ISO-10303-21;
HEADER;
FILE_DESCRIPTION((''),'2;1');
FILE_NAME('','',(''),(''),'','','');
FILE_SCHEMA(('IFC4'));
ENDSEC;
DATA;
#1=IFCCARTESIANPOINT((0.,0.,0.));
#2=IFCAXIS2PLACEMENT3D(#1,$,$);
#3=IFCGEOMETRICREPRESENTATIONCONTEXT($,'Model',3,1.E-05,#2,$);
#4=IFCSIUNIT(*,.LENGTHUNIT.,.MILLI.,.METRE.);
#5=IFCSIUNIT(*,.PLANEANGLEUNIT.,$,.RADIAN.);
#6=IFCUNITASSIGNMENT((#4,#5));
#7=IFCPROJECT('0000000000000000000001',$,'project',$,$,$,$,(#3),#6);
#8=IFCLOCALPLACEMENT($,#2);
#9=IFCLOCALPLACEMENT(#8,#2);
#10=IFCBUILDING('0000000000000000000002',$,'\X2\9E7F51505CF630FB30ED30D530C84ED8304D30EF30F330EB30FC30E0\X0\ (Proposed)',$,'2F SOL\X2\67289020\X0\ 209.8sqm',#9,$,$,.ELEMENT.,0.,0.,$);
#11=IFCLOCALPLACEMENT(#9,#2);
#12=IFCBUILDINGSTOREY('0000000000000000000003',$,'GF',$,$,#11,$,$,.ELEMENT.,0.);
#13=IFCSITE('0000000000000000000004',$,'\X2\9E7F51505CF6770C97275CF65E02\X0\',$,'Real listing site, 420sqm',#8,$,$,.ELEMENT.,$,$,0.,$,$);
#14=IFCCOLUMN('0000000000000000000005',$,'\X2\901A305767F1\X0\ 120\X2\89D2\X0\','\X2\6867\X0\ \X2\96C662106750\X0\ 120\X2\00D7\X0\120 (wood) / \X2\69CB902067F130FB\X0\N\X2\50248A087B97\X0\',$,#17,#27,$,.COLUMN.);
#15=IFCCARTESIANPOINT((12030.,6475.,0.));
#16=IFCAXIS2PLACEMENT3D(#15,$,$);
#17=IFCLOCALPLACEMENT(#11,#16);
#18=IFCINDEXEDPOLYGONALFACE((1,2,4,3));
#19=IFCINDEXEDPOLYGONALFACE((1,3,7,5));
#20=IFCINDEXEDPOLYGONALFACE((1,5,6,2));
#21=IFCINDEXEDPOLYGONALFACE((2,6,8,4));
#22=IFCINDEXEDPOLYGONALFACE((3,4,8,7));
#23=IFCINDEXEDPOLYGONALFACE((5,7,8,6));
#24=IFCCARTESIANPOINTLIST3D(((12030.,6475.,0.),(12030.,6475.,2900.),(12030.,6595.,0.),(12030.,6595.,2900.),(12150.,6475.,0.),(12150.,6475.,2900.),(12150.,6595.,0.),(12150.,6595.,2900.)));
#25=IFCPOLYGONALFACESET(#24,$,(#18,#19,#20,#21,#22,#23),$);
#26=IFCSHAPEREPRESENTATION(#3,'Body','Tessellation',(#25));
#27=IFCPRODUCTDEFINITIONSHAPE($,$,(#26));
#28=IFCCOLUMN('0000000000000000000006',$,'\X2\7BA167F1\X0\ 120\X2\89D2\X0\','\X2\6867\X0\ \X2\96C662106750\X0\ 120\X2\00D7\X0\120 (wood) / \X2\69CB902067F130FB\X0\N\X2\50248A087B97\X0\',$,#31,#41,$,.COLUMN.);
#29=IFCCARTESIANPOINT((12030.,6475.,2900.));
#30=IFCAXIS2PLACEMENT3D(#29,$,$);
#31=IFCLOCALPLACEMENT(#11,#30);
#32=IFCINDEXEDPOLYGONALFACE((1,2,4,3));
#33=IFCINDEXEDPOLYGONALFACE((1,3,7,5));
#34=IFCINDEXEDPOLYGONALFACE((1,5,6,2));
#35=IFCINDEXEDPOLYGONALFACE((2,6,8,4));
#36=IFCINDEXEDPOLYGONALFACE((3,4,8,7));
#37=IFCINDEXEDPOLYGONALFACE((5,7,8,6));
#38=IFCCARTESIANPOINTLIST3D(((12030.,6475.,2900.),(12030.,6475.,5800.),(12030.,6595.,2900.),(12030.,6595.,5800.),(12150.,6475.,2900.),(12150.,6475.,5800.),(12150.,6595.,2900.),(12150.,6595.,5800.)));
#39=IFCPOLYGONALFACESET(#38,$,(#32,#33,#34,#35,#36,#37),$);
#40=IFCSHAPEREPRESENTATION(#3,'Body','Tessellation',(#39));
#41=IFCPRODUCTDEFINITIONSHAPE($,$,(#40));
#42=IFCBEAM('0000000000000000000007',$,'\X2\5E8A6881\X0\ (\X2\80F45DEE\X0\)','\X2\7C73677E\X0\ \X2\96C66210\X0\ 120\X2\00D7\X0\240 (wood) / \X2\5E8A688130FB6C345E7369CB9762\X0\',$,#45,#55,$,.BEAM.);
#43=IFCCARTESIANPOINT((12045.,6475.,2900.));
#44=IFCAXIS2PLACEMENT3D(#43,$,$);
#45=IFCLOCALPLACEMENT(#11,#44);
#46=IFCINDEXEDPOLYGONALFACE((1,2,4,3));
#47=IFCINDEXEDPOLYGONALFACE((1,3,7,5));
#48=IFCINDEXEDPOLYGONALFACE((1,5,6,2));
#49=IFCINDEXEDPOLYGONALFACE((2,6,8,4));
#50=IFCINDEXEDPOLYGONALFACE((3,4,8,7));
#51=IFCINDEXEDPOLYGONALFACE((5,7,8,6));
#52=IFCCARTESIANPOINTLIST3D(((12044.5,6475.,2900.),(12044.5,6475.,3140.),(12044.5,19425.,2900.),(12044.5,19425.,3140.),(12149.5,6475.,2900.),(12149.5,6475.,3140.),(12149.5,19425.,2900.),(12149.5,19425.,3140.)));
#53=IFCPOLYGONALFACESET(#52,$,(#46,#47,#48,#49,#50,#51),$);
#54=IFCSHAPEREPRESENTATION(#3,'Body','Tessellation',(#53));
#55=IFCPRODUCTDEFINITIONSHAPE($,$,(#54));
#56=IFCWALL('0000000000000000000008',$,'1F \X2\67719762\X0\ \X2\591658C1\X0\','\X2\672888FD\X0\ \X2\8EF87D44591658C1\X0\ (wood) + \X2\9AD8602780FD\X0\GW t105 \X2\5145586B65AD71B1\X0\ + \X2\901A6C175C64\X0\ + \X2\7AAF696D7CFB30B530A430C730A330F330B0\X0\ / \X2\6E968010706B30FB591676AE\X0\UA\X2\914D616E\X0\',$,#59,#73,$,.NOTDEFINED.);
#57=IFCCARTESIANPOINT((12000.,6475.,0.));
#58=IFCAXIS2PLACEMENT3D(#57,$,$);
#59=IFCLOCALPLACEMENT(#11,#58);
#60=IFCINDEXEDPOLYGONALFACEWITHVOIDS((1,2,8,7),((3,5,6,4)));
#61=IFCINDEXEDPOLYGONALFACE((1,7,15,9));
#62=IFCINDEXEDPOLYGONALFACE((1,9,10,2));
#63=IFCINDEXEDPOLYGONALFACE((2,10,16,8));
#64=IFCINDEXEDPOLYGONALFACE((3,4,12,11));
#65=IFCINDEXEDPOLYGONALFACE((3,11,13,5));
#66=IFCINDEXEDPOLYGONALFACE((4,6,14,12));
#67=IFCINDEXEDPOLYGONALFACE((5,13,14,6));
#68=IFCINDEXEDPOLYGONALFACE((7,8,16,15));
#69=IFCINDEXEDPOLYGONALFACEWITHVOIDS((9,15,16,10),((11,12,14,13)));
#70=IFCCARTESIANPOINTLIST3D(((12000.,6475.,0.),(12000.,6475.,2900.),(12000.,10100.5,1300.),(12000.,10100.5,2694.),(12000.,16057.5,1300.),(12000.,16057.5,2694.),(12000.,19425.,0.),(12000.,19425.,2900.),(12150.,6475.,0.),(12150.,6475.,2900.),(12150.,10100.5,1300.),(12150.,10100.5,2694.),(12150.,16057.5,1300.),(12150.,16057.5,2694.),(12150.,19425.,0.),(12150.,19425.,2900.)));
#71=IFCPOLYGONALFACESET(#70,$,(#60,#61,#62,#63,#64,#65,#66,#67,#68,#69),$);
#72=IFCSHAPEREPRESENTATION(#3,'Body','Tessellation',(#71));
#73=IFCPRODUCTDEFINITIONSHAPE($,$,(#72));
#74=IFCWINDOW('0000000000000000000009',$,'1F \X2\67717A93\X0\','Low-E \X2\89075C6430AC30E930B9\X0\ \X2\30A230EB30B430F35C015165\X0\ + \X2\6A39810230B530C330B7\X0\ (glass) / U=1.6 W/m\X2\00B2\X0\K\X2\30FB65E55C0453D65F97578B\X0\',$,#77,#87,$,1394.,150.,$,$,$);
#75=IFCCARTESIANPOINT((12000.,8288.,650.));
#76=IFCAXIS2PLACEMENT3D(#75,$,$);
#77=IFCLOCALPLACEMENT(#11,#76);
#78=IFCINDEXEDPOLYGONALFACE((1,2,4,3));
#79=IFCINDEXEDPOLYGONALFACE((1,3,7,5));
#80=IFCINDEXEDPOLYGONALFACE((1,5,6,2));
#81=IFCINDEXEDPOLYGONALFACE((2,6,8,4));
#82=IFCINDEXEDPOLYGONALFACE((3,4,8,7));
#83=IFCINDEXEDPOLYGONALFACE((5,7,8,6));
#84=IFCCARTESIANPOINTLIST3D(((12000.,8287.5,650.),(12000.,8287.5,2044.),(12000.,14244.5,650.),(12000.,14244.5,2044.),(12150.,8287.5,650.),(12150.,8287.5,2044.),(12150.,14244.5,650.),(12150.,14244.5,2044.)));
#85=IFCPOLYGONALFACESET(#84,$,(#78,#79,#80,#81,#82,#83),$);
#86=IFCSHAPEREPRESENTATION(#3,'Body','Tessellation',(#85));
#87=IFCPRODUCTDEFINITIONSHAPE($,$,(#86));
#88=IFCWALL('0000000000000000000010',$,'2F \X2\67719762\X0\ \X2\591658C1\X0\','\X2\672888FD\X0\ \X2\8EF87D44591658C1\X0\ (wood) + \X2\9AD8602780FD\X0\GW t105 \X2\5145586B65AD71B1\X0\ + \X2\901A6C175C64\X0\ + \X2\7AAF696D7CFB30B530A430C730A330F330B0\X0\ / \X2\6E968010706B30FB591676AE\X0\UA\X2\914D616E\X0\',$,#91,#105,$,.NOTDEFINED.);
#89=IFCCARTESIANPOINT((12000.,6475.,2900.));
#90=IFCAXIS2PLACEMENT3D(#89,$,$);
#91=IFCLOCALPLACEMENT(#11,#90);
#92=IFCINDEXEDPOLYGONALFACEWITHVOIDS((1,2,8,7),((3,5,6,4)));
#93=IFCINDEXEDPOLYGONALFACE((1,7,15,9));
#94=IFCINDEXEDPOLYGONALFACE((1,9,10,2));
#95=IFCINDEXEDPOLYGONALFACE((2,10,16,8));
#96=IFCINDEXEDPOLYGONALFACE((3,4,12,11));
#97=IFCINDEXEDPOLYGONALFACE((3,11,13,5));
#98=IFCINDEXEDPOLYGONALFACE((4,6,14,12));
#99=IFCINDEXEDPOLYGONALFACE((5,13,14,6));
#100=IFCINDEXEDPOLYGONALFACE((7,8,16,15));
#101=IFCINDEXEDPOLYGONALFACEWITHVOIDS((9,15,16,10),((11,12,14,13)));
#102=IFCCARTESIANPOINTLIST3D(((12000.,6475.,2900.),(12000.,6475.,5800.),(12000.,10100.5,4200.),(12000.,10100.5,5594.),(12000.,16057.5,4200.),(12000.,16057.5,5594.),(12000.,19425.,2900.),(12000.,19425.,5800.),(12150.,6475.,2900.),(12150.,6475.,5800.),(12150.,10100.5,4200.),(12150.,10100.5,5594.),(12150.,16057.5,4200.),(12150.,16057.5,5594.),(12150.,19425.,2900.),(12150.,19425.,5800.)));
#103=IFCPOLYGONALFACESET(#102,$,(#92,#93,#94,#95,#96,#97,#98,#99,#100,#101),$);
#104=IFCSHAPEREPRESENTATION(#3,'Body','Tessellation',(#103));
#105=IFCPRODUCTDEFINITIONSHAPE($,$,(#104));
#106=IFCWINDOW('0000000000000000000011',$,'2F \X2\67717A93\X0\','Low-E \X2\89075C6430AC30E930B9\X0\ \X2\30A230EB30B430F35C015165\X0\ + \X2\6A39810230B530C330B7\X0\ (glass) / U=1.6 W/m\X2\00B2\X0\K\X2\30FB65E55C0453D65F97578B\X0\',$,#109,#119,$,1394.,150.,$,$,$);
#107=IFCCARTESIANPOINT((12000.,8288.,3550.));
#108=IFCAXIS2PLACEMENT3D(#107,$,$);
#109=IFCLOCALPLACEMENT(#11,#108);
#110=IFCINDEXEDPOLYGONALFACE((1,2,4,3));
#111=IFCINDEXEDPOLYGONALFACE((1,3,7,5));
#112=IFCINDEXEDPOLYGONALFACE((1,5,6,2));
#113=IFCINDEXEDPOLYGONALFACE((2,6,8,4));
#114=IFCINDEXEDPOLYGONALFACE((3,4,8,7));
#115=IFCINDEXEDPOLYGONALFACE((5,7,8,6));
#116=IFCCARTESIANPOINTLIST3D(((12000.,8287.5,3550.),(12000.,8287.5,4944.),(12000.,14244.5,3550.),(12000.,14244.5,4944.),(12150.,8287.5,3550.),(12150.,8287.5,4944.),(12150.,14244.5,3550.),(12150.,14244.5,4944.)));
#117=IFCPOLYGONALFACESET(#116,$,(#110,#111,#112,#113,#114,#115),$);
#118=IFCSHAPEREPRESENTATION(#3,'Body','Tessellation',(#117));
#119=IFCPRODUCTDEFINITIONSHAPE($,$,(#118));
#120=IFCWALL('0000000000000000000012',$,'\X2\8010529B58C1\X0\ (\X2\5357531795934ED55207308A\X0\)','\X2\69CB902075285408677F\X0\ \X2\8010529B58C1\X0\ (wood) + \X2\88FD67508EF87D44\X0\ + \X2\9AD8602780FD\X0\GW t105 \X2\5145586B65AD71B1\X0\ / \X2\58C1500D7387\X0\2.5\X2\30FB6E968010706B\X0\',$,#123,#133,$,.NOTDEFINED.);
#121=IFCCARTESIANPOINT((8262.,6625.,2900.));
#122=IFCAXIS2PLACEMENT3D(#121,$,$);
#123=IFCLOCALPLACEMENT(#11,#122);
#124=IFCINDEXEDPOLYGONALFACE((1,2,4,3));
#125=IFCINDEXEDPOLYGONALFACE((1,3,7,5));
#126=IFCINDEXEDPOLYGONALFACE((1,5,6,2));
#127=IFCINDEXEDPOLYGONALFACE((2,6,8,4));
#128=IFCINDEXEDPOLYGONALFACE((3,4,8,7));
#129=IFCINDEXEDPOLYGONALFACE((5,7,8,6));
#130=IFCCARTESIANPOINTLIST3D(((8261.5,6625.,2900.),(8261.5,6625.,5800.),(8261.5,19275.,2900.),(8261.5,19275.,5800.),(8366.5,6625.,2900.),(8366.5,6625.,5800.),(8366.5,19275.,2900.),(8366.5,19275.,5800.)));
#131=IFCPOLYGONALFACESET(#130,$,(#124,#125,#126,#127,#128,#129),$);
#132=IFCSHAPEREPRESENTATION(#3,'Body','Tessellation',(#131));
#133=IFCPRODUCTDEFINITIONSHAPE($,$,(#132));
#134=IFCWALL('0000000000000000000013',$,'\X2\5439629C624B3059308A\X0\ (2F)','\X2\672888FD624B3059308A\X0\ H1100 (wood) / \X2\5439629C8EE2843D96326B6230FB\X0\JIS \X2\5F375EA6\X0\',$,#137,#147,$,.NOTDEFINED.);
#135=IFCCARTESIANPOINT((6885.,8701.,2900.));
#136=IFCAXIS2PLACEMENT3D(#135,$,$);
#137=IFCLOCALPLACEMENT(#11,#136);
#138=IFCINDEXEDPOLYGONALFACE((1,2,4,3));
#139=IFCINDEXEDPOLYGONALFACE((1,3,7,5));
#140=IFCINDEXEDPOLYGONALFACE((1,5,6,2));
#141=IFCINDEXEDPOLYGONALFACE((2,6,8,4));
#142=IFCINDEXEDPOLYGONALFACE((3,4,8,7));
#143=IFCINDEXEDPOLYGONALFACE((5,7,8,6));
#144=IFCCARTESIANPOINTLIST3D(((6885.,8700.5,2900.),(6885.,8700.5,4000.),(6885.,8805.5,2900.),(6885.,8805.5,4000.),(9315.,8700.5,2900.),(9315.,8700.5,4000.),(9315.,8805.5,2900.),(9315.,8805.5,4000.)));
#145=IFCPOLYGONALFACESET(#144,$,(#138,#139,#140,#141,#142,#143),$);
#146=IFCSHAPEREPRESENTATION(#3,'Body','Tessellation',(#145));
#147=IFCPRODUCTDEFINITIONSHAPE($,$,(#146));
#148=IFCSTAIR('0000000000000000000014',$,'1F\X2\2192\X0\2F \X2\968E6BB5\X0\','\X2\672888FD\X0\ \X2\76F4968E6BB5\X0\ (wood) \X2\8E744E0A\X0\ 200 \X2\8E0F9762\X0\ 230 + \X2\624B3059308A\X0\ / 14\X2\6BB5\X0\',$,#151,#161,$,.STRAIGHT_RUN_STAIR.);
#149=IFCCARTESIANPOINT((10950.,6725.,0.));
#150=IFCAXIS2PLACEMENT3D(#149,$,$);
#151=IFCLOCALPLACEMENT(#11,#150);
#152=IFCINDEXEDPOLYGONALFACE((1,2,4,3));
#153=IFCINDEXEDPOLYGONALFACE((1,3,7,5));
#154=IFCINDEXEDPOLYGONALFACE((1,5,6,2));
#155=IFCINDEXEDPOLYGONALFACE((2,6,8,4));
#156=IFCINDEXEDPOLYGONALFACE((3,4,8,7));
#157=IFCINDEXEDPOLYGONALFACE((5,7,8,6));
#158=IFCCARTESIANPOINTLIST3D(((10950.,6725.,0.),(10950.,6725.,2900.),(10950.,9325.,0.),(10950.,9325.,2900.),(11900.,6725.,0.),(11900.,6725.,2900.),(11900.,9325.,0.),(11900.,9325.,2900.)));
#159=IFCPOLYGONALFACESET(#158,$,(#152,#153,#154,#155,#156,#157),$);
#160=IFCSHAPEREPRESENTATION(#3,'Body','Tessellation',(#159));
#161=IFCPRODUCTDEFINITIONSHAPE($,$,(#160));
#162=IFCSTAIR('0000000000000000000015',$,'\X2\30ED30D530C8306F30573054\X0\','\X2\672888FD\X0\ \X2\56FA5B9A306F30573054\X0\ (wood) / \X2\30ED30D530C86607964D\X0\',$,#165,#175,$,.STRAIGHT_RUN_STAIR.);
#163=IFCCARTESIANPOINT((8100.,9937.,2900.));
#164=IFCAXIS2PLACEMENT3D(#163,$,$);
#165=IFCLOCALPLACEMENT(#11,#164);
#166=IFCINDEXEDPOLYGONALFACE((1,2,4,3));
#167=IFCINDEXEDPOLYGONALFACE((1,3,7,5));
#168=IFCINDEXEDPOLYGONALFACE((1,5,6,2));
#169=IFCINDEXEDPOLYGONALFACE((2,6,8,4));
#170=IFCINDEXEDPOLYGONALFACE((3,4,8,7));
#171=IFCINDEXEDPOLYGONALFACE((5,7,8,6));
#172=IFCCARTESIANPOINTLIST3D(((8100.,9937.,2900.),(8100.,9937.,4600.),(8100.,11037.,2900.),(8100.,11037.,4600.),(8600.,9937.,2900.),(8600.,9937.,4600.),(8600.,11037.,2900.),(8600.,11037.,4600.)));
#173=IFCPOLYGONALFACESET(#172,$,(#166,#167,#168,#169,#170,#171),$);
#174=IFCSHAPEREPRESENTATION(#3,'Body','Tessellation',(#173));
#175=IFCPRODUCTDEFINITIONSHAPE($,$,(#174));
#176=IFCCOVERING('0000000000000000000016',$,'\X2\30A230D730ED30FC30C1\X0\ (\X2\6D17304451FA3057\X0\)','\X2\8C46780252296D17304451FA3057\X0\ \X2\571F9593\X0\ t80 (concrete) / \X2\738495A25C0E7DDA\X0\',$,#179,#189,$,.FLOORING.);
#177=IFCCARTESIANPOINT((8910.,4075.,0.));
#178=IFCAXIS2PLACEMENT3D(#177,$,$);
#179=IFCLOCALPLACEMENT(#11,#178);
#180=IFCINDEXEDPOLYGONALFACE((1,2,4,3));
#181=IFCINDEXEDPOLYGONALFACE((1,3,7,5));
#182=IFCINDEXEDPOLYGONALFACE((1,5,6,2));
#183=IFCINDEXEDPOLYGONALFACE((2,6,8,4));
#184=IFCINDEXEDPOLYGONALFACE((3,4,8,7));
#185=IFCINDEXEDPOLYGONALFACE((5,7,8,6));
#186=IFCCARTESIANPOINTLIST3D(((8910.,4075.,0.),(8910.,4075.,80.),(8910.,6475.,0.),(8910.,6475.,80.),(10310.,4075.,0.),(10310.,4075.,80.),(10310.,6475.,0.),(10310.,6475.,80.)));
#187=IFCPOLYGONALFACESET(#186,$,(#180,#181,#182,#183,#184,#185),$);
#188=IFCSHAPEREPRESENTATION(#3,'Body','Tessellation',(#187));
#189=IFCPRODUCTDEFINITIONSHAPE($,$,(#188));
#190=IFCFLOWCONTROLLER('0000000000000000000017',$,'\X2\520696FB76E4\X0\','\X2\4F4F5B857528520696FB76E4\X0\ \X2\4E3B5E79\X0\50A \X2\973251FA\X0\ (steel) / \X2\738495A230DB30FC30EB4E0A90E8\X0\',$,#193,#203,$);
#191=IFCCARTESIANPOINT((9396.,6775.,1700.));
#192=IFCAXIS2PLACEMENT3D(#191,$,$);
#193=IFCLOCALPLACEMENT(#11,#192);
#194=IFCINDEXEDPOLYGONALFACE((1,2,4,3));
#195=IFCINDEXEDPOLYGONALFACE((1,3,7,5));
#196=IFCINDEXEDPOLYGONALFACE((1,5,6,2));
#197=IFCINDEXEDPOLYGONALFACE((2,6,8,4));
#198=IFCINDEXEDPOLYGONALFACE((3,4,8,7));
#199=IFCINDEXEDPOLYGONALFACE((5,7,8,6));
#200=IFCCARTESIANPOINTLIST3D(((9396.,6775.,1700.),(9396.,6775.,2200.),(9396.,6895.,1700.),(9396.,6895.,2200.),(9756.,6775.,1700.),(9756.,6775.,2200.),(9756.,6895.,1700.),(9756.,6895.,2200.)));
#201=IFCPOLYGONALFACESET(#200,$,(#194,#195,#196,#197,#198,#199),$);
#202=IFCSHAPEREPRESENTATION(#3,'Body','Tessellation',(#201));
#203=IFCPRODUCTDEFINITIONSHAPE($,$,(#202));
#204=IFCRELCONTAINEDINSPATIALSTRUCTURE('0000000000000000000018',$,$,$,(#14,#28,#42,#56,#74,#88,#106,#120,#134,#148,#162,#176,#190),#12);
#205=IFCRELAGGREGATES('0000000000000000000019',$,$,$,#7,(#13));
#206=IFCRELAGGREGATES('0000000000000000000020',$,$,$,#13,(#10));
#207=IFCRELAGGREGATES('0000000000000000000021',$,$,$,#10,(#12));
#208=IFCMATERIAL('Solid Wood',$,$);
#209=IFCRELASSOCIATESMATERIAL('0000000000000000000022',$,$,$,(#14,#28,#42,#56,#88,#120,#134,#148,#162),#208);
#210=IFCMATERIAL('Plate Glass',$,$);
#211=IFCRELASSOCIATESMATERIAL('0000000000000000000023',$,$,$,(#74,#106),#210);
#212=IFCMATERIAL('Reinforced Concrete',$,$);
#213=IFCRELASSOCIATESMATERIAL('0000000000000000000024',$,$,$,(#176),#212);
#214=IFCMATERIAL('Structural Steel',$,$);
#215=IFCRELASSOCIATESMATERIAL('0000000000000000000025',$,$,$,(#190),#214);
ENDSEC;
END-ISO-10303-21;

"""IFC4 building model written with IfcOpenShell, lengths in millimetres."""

from ifc_helpers import new_model, si_unit, frame, frame_2d, origin, place, context, project, spatial, rectangle, extrude, material, element, fill, save


model = new_model("IFC4")

# Units and contexts
model_context = context("Model", 3, precision=1e-05, world=origin())
ifc_project = project(units=[si_unit("LENGTHUNIT", "METRE", prefix="MILLI"), si_unit("PLANEANGLEUNIT", "RADIAN")], contexts=[model_context])

# Site, building, storey
site_placement = place(None, origin())
site = spatial("IfcSite", under=ifc_project, at=site_placement, Name="鹿児島県霧島市", ObjectType="Real listing site, 420sqm", CompositionType="ELEMENT", RefElevation=0.0)
building_placement = place(site_placement, origin())
building = spatial("IfcBuilding", under=site, at=building_placement, Name="鹿児島・ロフト付きワンルーム (Proposed)", ObjectType="2F SOL木造 209.8sqm", CompositionType="ELEMENT", ElevationOfRefHeight=0.0, ElevationOfTerrain=0.0)
storey_placement = place(building_placement, origin())
storey = spatial("IfcBuildingStorey", under=building, at=storey_placement, Name="GF", CompositionType="ELEMENT", Elevation=0.0)

# Columns
ifc_material_1 = material(Name="Solid Wood")
column_1_placement = place(storey_placement, frame((12030.0, 6475.0, 0.0)))
element("IfcColumn", 1, at=column_1_placement, inside=storey, material=ifc_material_1, Name="通し柱 120角", Description="桧 集成材 120×120 (wood) / 構造柱・N値計算", PredefinedType="COLUMN", context=model_context, shape_type="SweptSolid", body=[
    extrude(rectangle(XDim=120.0, YDim=120.0, at=frame_2d((60.0, 60.0))), frame((12030.0, 6475.0, 0.0)), (0.0, 0.0, 1.0), 2900.0),
])
column_2_placement = place(storey_placement, frame((12030.0, 6475.0, 2900.0)))
element("IfcColumn", 2, at=column_2_placement, inside=storey, material=ifc_material_1, Name="管柱 120角", Description="桧 集成材 120×120 (wood) / 構造柱・N値計算", PredefinedType="COLUMN", context=model_context, shape_type="SweptSolid", body=[
    extrude(rectangle(XDim=120.0, YDim=120.0, at=frame_2d((60.0, 60.0))), frame((12030.0, 6475.0, 2900.0)), (0.0, 0.0, 1.0), 2900.0),
])

# Beam
beam_1_placement = place(storey_placement, frame((12045.0, 6475.0, 2900.0)))
element("IfcBeam", 3, at=beam_1_placement, inside=storey, material=ifc_material_1, Name="床梁 (胴差)", Description="米松 集成 120×240 (wood) / 床梁・水平構面", PredefinedType="BEAM", context=model_context, shape_type="SweptSolid", body=[
    extrude(rectangle(XDim=105.0, YDim=12950.0, at=frame_2d((52.0, 6475.0))), frame((12045.0, 6475.0, 2900.0)), (0.0, 0.0, 1.0), 240.0),
])

# Wall, opening, window
wall_1_placement = place(storey_placement, frame((12000.0, 6475.0, 0.0)))
wall_1 = element("IfcWall", 4, at=wall_1_placement, inside=storey, material=ifc_material_1, Name="1F 東面 外壁", Description="木製 軸組外壁 (wood) + 高性能GW t105 充填断熱 + 通気層 + 窯業系サイディング / 準耐火・外皮UA配慮", PredefinedType="NOTDEFINED", context=model_context, shape_type="SweptSolid", body=[
    extrude(rectangle(XDim=150.0, YDim=12950.0, at=frame_2d((75.0, 6475.0))), frame((12000.0, 6475.0, 0.0)), (0.0, 0.0, 1.0), 2900.0),
])
opening_1_placement = place(storey_placement, frame((12000.0, 8288.0, 650.0)))
opening_1 = element("IfcOpeningElement", 5, at=opening_1_placement, cuts=wall_1, PredefinedType="NOTDEFINED", context=model_context, shape_type="SweptSolid", body=[
    extrude(rectangle(XDim=150.0, YDim=5957.0, at=frame_2d((75.0, 2978.0))), frame((12000.0, 8288.0, 650.0)), (0.0, 0.0, 1.0), 1394.0),
])
ifc_material_2 = material(Name="Plate Glass")
window_1_placement = place(storey_placement, frame((12000.0, 8288.0, 650.0)))
window_1 = element("IfcWindow", 6, at=window_1_placement, inside=storey, material=ifc_material_2, Name="1F 東窓", Description="Low-E 複層ガラス アルゴン封入 + 樹脂サッシ (glass) / U=1.6 W/m²K・日射取得型", OverallHeight=1394.0, OverallWidth=150.0, context=model_context, shape_type="SweptSolid", body=[
    extrude(rectangle(XDim=150.0, YDim=5957.0, at=frame_2d((75.0, 2978.0))), frame((12000.0, 8288.0, 650.0)), (0.0, 0.0, 1.0), 1394.0),
])
fill(opening_1, window_1)

# Wall, opening, window
wall_2_placement = place(storey_placement, frame((12000.0, 6475.0, 2900.0)))
wall_2 = element("IfcWall", 7, at=wall_2_placement, inside=storey, material=ifc_material_1, Name="2F 東面 外壁", Description="木製 軸組外壁 (wood) + 高性能GW t105 充填断熱 + 通気層 + 窯業系サイディング / 準耐火・外皮UA配慮", PredefinedType="NOTDEFINED", context=model_context, shape_type="SweptSolid", body=[
    extrude(rectangle(XDim=150.0, YDim=12950.0, at=frame_2d((75.0, 6475.0))), frame((12000.0, 6475.0, 2900.0)), (0.0, 0.0, 1.0), 2900.0),
])
opening_2_placement = place(storey_placement, frame((12000.0, 8288.0, 3550.0)))
opening_2 = element("IfcOpeningElement", 8, at=opening_2_placement, cuts=wall_2, PredefinedType="NOTDEFINED", context=model_context, shape_type="SweptSolid", body=[
    extrude(rectangle(XDim=150.0, YDim=5957.0, at=frame_2d((75.0, 2978.0))), frame((12000.0, 8288.0, 3550.0)), (0.0, 0.0, 1.0), 1394.0),
])
window_2_placement = place(storey_placement, frame((12000.0, 8288.0, 3550.0)))
window_2 = element("IfcWindow", 9, at=window_2_placement, inside=storey, material=ifc_material_2, Name="2F 東窓", Description="Low-E 複層ガラス アルゴン封入 + 樹脂サッシ (glass) / U=1.6 W/m²K・日射取得型", OverallHeight=1394.0, OverallWidth=150.0, context=model_context, shape_type="SweptSolid", body=[
    extrude(rectangle(XDim=150.0, YDim=5957.0, at=frame_2d((75.0, 2978.0))), frame((12000.0, 8288.0, 3550.0)), (0.0, 0.0, 1.0), 1394.0),
])
fill(opening_2, window_2)

# Walls
wall_3_placement = place(storey_placement, frame((8262.0, 6625.0, 2900.0)))
element("IfcWall", 10, at=wall_3_placement, inside=storey, material=ifc_material_1, Name="耐力壁 (南北間仕切り)", Description="構造用合板 耐力壁 (wood) + 製材軸組 + 高性能GW t105 充填断熱 / 壁倍率2.5・準耐火", PredefinedType="NOTDEFINED", context=model_context, shape_type="SweptSolid", body=[
    extrude(rectangle(XDim=105.0, YDim=12650.0, at=frame_2d((52.0, 6325.0))), frame((8262.0, 6625.0, 2900.0)), (0.0, 0.0, 1.0), 2900.0),
])
wall_4_placement = place(storey_placement, frame((6885.0, 8701.0, 2900.0)))
element("IfcWall", 11, at=wall_4_placement, inside=storey, material=ifc_material_1, Name="吹抜手すり (2F)", Description="木製手すり H1100 (wood) / 吹抜転落防止・JIS 強度", PredefinedType="NOTDEFINED", context=model_context, shape_type="SweptSolid", body=[
    extrude(rectangle(XDim=2430.0, YDim=105.0, at=frame_2d((1215.0, 52.0))), frame((6885.0, 8701.0, 2900.0)), (0.0, 0.0, 1.0), 1100.0),
])

# Stairs
stair_1_placement = place(storey_placement, frame((10950.0, 6725.0, 0.0)))
element("IfcStair", 12, at=stair_1_placement, inside=storey, material=ifc_material_1, Name="1F→2F 階段", Description="木製 直階段 (wood) 蹴上 200 踏面 230 + 手すり / 14段", PredefinedType="STRAIGHT_RUN_STAIR", context=model_context, shape_type="SweptSolid", body=[
    extrude(rectangle(XDim=950.0, YDim=2600.0, at=frame_2d((475.0, 1300.0))), frame((10950.0, 6725.0, 0.0)), (0.0, 0.0, 1.0), 2900.0),
])
stair_2_placement = place(storey_placement, frame((8100.0, 9937.0, 2900.0)))
element("IfcStair", 13, at=stair_2_placement, inside=storey, material=ifc_material_1, Name="ロフトはしご", Description="木製 固定はしご (wood) / ロフト昇降", PredefinedType="STRAIGHT_RUN_STAIR", context=model_context, shape_type="SweptSolid", body=[
    extrude(rectangle(XDim=500.0, YDim=1100.0, at=frame_2d((250.0, 550.0))), frame((8100.0, 9937.0, 2900.0)), (0.0, 0.0, 1.0), 1700.0),
])

# Covering
ifc_material_3 = material(Name="Reinforced Concrete")
covering_placement = place(storey_placement, frame((8910.0, 4075.0, 0.0)))
element("IfcCovering", 14, at=covering_placement, inside=storey, material=ifc_material_3, Name="アプローチ (洗い出し)", Description="豆砂利洗い出し 土間 t80 (concrete) / 玄関導線", PredefinedType="FLOORING", context=model_context, shape_type="SweptSolid", body=[
    extrude(rectangle(XDim=1400.0, YDim=2400.0, at=frame_2d((700.0, 1200.0))), frame((8910.0, 4075.0, 0.0)), (0.0, 0.0, 1.0), 80.0),
])

# Flow controller
ifc_material_4 = material(Name="Structural Steel")
flow_controller_placement = place(storey_placement, frame((9396.0, 6775.0, 1700.0)))
element("IfcFlowController", 15, at=flow_controller_placement, inside=storey, material=ifc_material_4, Name="分電盤", Description="住宅用分電盤 主幹50A 露出 (steel) / 玄関ホール上部", context=model_context, shape_type="SweptSolid", body=[
    extrude(rectangle(XDim=360.0, YDim=120.0, at=frame_2d((180.0, 60.0))), frame((9396.0, 6775.0, 1700.0)), (0.0, 0.0, 1.0), 500.0),
])

save(model, "model.ifc")
